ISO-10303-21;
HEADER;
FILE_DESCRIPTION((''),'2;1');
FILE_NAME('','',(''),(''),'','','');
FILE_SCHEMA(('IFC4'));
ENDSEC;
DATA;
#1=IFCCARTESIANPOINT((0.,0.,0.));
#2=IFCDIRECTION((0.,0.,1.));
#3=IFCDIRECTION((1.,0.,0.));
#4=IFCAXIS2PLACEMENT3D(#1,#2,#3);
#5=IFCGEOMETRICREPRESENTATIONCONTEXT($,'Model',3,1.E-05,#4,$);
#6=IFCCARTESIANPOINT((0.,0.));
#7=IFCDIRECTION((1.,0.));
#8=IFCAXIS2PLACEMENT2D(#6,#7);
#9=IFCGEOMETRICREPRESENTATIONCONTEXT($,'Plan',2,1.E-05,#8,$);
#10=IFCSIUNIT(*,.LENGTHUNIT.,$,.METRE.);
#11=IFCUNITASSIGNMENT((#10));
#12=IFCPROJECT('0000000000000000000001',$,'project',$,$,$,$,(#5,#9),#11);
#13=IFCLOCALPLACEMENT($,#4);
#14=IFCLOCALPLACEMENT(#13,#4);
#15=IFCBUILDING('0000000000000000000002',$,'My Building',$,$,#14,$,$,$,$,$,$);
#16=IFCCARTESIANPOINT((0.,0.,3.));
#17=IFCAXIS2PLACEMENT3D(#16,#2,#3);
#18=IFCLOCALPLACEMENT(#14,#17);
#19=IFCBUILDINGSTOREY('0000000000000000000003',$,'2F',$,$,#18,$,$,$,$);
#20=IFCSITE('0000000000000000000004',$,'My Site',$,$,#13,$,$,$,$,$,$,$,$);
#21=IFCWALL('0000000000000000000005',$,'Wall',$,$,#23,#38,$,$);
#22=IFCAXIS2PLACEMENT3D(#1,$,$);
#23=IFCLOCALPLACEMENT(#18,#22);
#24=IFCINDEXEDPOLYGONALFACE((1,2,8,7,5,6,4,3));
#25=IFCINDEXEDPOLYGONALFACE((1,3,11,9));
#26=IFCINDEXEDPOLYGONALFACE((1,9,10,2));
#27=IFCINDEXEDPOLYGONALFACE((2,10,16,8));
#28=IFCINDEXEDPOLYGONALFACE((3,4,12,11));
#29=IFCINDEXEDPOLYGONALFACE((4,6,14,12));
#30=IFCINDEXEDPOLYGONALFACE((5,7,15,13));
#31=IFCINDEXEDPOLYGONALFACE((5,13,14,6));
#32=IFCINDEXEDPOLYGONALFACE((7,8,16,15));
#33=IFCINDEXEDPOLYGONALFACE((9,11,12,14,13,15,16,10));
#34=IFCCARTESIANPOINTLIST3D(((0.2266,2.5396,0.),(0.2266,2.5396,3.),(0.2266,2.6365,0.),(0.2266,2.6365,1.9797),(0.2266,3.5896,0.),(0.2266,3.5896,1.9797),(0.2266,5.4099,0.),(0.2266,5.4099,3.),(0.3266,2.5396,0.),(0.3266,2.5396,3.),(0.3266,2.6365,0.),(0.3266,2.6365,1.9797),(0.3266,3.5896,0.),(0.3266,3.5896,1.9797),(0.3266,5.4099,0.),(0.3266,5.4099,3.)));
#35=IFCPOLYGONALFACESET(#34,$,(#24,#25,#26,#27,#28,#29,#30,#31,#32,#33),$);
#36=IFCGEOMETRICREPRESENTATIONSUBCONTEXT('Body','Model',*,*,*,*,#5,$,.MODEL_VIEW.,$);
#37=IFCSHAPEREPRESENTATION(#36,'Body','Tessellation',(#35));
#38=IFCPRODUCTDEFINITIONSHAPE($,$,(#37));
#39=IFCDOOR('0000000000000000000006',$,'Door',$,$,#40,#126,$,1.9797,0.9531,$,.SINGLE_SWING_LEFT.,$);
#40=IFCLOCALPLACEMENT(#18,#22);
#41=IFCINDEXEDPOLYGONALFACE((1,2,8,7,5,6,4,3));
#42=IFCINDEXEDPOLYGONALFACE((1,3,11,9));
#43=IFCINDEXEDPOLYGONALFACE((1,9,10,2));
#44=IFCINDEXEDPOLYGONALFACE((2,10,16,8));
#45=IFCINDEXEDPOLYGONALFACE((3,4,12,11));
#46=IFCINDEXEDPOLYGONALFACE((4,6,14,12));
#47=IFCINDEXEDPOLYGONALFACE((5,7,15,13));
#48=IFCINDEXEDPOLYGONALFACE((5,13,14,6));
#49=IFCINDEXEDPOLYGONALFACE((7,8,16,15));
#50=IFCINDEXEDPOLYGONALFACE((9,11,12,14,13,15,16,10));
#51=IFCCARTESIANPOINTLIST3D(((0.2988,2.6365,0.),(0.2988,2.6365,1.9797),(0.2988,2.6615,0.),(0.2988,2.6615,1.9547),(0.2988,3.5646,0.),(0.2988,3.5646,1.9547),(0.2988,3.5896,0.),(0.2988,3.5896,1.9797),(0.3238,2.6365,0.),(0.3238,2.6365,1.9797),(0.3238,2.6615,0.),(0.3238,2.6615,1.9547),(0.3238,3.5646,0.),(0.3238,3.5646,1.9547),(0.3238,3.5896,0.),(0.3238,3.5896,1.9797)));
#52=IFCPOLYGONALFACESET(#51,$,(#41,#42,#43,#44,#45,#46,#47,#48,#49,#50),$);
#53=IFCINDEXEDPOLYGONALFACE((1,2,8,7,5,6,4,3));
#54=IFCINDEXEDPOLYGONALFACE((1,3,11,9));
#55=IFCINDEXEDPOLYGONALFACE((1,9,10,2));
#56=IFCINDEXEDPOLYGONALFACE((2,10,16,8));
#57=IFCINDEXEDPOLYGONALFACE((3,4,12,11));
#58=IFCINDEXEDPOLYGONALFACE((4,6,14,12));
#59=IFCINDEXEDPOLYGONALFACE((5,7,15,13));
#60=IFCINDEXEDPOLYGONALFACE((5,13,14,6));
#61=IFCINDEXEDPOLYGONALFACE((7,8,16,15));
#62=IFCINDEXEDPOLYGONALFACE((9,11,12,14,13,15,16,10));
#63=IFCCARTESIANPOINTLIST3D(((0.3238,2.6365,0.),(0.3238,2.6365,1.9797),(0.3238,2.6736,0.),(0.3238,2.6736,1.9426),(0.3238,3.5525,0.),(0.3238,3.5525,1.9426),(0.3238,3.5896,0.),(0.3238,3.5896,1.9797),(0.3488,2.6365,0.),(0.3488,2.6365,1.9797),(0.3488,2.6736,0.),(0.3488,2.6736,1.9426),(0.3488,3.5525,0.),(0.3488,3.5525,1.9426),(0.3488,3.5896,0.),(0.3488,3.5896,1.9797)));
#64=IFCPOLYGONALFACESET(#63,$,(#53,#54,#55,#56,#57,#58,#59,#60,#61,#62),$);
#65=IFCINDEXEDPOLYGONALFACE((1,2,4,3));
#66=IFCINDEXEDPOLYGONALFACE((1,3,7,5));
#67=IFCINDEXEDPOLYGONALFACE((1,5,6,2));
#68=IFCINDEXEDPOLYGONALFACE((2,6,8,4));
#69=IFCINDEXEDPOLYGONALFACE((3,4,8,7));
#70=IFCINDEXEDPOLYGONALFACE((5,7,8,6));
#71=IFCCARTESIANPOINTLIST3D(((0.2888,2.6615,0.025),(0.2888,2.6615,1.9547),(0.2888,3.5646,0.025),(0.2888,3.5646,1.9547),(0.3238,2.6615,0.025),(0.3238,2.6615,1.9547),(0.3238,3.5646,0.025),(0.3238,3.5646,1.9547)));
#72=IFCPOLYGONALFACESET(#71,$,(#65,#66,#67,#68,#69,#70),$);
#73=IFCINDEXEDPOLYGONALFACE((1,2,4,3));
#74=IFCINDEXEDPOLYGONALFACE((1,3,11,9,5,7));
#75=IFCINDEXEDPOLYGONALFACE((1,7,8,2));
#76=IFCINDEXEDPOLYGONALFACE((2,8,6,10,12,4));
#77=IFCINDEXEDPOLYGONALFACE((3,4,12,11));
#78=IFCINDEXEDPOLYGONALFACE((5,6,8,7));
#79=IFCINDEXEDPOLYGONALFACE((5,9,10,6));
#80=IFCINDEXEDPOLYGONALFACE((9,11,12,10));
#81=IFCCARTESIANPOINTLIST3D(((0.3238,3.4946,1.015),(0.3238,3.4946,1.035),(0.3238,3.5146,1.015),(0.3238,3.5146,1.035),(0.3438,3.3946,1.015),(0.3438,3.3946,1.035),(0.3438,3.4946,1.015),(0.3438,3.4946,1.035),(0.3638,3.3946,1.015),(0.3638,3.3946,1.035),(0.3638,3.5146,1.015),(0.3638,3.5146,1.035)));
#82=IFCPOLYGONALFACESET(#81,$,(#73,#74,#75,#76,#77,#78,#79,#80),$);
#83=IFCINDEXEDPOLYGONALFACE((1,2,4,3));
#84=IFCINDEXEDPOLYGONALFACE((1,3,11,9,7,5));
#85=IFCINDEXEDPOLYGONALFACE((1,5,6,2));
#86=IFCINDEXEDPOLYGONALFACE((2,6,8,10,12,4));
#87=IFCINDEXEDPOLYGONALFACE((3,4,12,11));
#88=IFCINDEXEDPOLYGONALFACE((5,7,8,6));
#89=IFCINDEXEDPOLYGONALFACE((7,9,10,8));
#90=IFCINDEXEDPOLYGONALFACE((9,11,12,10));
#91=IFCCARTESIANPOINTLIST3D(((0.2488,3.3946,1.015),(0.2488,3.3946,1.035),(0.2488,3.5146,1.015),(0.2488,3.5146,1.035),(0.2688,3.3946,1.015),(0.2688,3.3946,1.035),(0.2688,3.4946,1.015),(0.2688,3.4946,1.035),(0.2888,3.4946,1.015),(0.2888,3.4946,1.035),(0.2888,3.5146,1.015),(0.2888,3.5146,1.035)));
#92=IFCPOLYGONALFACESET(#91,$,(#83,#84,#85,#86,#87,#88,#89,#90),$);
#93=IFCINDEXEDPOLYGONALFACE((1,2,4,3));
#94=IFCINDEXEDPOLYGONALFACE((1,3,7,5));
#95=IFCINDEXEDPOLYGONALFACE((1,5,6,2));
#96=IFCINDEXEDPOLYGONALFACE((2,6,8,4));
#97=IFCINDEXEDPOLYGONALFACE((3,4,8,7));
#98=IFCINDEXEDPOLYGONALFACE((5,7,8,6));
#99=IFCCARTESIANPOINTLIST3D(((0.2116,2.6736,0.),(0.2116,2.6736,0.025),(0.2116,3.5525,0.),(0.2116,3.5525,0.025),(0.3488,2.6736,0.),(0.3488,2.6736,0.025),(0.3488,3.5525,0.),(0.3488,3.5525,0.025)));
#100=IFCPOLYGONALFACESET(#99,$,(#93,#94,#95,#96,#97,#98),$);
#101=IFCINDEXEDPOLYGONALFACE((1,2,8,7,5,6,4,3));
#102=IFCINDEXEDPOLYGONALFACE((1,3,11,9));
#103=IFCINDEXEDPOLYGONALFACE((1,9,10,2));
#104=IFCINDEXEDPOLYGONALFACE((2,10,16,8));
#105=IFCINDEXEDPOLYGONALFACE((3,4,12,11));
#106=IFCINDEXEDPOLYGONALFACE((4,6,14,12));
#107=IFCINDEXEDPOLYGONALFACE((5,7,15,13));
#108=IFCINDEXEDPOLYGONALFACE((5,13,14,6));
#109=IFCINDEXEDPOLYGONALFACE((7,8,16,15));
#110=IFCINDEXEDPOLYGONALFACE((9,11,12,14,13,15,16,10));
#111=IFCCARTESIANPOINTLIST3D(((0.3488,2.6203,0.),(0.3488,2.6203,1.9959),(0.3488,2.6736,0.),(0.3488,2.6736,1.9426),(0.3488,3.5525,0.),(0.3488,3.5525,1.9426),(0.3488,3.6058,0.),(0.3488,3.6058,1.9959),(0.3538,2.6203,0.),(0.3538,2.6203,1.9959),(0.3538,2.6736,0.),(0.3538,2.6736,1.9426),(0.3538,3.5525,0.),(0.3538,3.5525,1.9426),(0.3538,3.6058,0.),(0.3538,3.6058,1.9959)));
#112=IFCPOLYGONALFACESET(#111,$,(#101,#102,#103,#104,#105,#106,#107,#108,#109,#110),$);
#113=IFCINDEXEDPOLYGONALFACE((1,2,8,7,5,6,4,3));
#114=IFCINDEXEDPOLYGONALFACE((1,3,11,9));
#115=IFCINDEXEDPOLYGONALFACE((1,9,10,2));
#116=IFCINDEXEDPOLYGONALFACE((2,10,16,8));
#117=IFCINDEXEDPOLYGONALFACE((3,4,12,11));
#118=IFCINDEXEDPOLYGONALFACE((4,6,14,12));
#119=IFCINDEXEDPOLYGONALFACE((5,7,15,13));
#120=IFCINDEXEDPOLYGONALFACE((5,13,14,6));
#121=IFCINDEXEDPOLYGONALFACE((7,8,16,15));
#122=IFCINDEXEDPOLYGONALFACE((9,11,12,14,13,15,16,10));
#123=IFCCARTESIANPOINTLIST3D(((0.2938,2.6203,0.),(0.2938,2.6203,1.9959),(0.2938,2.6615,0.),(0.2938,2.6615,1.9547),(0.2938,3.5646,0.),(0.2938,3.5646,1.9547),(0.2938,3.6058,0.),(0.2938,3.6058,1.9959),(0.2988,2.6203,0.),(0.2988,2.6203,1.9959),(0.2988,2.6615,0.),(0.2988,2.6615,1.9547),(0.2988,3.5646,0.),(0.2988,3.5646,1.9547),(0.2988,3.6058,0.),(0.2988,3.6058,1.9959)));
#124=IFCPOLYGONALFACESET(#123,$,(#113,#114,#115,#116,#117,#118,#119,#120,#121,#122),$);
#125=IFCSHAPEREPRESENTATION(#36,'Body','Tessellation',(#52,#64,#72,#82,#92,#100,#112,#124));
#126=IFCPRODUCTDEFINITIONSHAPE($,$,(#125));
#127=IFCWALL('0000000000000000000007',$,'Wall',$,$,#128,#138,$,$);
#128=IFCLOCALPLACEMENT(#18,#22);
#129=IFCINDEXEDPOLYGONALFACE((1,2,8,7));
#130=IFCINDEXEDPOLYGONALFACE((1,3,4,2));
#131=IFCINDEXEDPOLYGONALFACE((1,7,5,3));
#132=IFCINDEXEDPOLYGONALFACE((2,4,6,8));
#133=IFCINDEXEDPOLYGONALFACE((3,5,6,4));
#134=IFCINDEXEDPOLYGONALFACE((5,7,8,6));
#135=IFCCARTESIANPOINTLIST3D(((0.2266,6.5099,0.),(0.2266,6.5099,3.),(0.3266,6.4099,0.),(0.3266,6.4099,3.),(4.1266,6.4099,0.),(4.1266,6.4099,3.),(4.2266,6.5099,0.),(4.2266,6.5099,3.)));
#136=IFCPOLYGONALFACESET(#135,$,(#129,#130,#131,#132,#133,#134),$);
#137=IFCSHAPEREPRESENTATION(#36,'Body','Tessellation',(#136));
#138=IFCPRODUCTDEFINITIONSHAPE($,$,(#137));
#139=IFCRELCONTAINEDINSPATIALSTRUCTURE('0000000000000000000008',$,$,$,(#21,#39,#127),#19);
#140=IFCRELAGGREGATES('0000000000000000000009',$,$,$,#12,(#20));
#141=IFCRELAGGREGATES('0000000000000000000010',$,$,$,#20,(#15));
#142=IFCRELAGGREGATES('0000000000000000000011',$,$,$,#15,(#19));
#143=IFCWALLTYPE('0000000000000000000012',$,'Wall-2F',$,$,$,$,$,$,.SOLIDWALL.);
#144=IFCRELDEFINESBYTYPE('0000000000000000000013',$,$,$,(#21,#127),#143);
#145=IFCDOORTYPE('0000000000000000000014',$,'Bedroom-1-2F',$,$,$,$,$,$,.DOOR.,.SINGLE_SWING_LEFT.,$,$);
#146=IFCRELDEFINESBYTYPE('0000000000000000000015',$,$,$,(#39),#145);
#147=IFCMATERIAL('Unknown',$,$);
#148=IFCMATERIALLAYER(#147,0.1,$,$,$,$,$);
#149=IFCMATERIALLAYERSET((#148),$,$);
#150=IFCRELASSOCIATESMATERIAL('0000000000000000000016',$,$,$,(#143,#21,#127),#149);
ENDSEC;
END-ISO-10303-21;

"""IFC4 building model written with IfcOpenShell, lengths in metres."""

from ifc_helpers import new_model, entity, si_unit, frame, origin_with_axes, origin_2d_with_axis, place, context, subcontext, project, spatial, line, indexed_curve, outline, extrude, shape, source, transform, mapped, material, layer, layer_set, layer_usage, type_object, type_shapes, element, fill, save


model = new_model("IFC4")

# Units and contexts
model_context = context("Model", 3, precision=1e-05, world=origin_with_axes())
plan_context = context("Plan", 2, precision=1e-05, world=origin_2d_with_axis())
body_context_1 = subcontext(model_context, "Body", "Model", "MODEL_VIEW")
body_context_2 = subcontext(plan_context, "Body", "Plan", "PLAN_VIEW")
ifc_project = project(units=[si_unit("LENGTHUNIT", "METRE")], contexts=[model_context, plan_context])

# Site, building, storey
site_placement = place(None, origin_with_axes())
site = spatial("IfcSite", under=ifc_project, at=site_placement, Name="My Site")
building_placement = place(site_placement, origin_with_axes())
building = spatial("IfcBuilding", under=site, at=building_placement, Name="My Building")
storey_placement = place(building_placement, frame((0.0, 0.0, 3.0), z_axis=(0.0, 0.0, 1.0), x_axis=(1.0, 0.0, 0.0)))
storey = spatial("IfcBuildingStorey", under=building, at=storey_placement, Name="2F")

# Shared definitions
ifc_material = material(Name="Unknown")

# Shared definitions
ifc_layer_1 = layer(ifc_material, 0.1)
ifc_layer_set_1 = layer_set([ifc_layer_1])
wall_type = type_object("IfcWallType", Name="Wall-2F", PredefinedType="SOLIDWALL", material=ifc_layer_set_1)

# Wall, opening, door
ifc_layer_usage_1 = layer_usage(ifc_layer_set_1, "AXIS2", "POSITIVE", 0.0)
wall_1_placement = place(storey_placement, frame((0.3266, 2.5396, 0.0), z_axis=(0.0, 0.0, 1.0), x_axis=(0.0, 1.0, 0.0)))
wall_1 = element("IfcWall", 1, at=wall_1_placement, inside=storey, type_object=wall_type, material=ifc_layer_usage_1, Name="Wall", context=body_context_1, shape_type="SweptSolid", body=[
    extrude(outline(indexed_curve([(0.0, 0.0), (0.0, 0.1), (2.8703, 0.1), (2.8703, 0.0)], segments=[line(1, 2, 3, 4, 1)])), origin_with_axes(), (0.0, 0.0, 1.0), 3.0),
])
shared_shape_1 = source(origin_with_axes(), body_context_1, "Body", "SweptSolid", [
    extrude(outline(indexed_curve([(0.0, 0.0), (0.9531, 0.0), (0.9531, 1.9797), (0.0, 1.9797)], segments=[line(1, 2, 3, 4, 1)])), frame((0.0, -0.6, 0.0), z_axis=(0.0, -1.0, 0.0), x_axis=(1.0, 0.0, 0.0)), (0.0, 0.0, -1.0), 1.2),
])
opening_1_placement = place(wall_1_placement, frame((0.0969, -0.0222, 0.0), z_axis=(0.0, 0.0, 1.0), x_axis=(1.0, 0.0, 0.0)))
opening_1 = element("IfcOpeningElement", 2, at=opening_1_placement, cuts=wall_1, PredefinedType="OPENING", context=body_context_1, shape_type="MappedRepresentation", body=[
    mapped(shared_shape_1, transform((0.0, 0.0, 0.0), x_axis=(1.0, 0.0, 0.0), y_axis=(0.0, 1.0, 0.0), z_axis=(0.0, 0.0, 1.0), scale=1.0)),
])
door_type_1 = type_object("IfcDoorType", Name="Bedroom-1-2F", OperationType="SINGLE_SWING_LEFT", PredefinedType="DOOR")
shared_shape_2 = source(origin_with_axes(), body_context_1, "Body", "SweptSolid", [
    extrude(outline(indexed_curve([(0.0, 0.0), (0.0, 1.9797), (0.9531, 1.9797), (0.9531, 0.0), (0.9281, 0.0), (0.9281, 1.9547), (0.025, 1.9547), (0.025, 0.0)], segments=[line(1, 2, 3, 4, 5, 6, 7, 8, 1)])), frame((0.0, 0.025, 0.0), z_axis=(0.0, -1.0, 0.0), x_axis=(1.0, 0.0, 0.0)), (0.0, 0.0, -1.0), 0.025),
    extrude(outline(indexed_curve([(0.0, 0.0), (0.0, 1.9797), (0.9531, 1.9797), (0.9531, 0.0), (0.9161, 0.0), (0.9161, 1.9426), (0.0371, 1.9426), (0.0371, 0.0)], segments=[line(1, 2, 3, 4, 5, 6, 7, 8, 1)])), frame((0.0, 0.0, 0.0), z_axis=(0.0, -1.0, 0.0), x_axis=(1.0, 0.0, 0.0)), (0.0, 0.0, -1.0), 0.025),
    extrude(outline(indexed_curve([(0.0, 0.0), (0.9031, 0.0), (0.9031, 0.035), (0.0, 0.035)], segments=[line(1, 2, 3, 4, 1)])), frame((0.025, 0.025, 0.025), z_axis=(0.0, 0.0, 1.0), x_axis=(1.0, 0.0, 0.0)), (0.0, 0.0, 1.0), 1.9297),
    extrude(outline(indexed_curve([(0.0, 0.0), (0.0, -0.04), (-0.12, -0.04), (-0.12, -0.02), (-0.02, -0.02), (-0.02, 0.0)], segments=[line(1, 2, 3, 4, 5, 6, 1)])), frame((0.8781, 0.025, 1.015), z_axis=(0.0, 0.0, 1.0), x_axis=(1.0, 0.0, 0.0)), (0.0, 0.0, 1.0), 0.02),
    extrude(outline(indexed_curve([(0.0, 0.0), (0.0, 0.04), (-0.12, 0.04), (-0.12, 0.02), (-0.02, 0.02), (-0.02, 0.0)], segments=[line(1, 2, 3, 4, 5, 6, 1)])), frame((0.8781, 0.06, 1.015), z_axis=(0.0, 0.0, 1.0), x_axis=(1.0, 0.0, 0.0)), (0.0, 0.0, 1.0), 0.02),
    extrude(outline(indexed_curve([(0.0, 0.0), (0.879, 0.0), (0.879, 0.1372), (0.0, 0.1372)], segments=[line(1, 2, 3, 4, 1)])), frame((0.0371, 0.0, 0.0), z_axis=(0.0, 0.0, 1.0), x_axis=(1.0, 0.0, 0.0)), (0.0, 0.0, 1.0), 0.025),
    extrude(outline(indexed_curve([(0.0, 0.0), (0.0, 1.9959), (0.9855, 1.9959), (0.9855, 0.0), (0.9322, 0.0), (0.9322, 1.9426), (0.0532, 1.9426), (0.0532, 0.0)], segments=[line(1, 2, 3, 4, 5, 6, 7, 8, 1)])), frame((-0.0162, -0.005, 0.0), z_axis=(0.0, -1.0, 0.0), x_axis=(1.0, 0.0, 0.0)), (0.0, 0.0, -1.0), 0.005),
    extrude(outline(indexed_curve([(0.0, 0.0), (0.0, 1.9959), (0.9855, 1.9959), (0.9855, 0.0), (0.9443, 0.0), (0.9443, 1.9547), (0.0412, 1.9547), (0.0412, 0.0)], segments=[line(1, 2, 3, 4, 5, 6, 7, 8, 1)])), frame((-0.0162, 0.05, 0.0), z_axis=(0.0, -1.0, 0.0), x_axis=(1.0, 0.0, 0.0)), (0.0, 0.0, -1.0), 0.005),
])
shared_shape_3 = source(origin_with_axes(), body_context_2, "Body", "Curve2D", [
    entity("IfcIndexedPolyCurve", entity("IfcCartesianPointList2D", [[0.0, 0.0], [0.0, 0.05], [0.025, 0.05], [0.025, 0.025], [0.0371, 0.025], [0.0371, 0.0]]), [entity("IfcLineIndex", [1, 2, 3, 4, 5, 6, 1])]),
    entity("IfcIndexedPolyCurve", entity("IfcCartesianPointList2D", [[0.9531, 0.0], [0.9531, 0.05], [0.9281, 0.05], [0.9281, 0.025], [0.9161, 0.025], [0.9161, 0.0]]), [entity("IfcLineIndex", [1, 2, 3, 4, 5, 6, 1])]),
    entity("IfcTrimmedCurve", entity("IfcEllipse", entity("IfcAxis2Placement2D", entity("IfcCartesianPoint", [0.06, 0.05]), entity("IfcDirection", [1.0, 0.0])), 0.8681, 0.9031), [entity("IfcCartesianPoint", [0.9281, 0.05])], [entity("IfcCartesianPoint", [0.06, 0.9531])], True, "CARTESIAN"),
    entity("IfcIndexedPolyCurve", entity("IfcCartesianPointList2D", [[0.025, 0.05], [0.06, 0.05], [0.06, 0.9531], [0.025, 0.9531]]), [entity("IfcLineIndex", [1, 2, 3, 4, 1])]),
])
type_shapes(door_type_1, [shared_shape_2, shared_shape_3])
door_1_placement = place(opening_1_placement, frame((0.0, 0.0, 0.0), z_axis=(0.0, 0.0, 1.0), x_axis=(1.0, 0.0, 0.0)))
door_1 = element("IfcDoor", 3, at=door_1_placement, inside=storey, type_object=door_type_1, Name="Door", OperationType="SINGLE_SWING_LEFT", OverallHeight=1.9797, OverallWidth=0.9531, shapes=[
    shape(body_context_1, "Body", "MappedRepresentation", [mapped(shared_shape_2, transform((0.0, 0.0, 0.0), x_axis=(1.0, 0.0, 0.0), y_axis=(0.0, 1.0, 0.0), z_axis=(0.0, 0.0, 1.0), scale=1.0))]),
    shape(body_context_2, "Body", "MappedRepresentation", [mapped(shared_shape_3, transform((0.0, 0.0, 0.0), x_axis=(1.0, 0.0, 0.0), y_axis=(0.0, 1.0, 0.0), z_axis=(0.0, 0.0, 1.0), scale=1.0))]),
])
fill(opening_1, door_1)

# Wall
ifc_layer_usage_2 = layer_usage(ifc_layer_set_1, "AXIS2", "POSITIVE", 0.0)
wall_2_placement = place(storey_placement, frame((0.2266, 6.4099, 0.0), z_axis=(0.0, 0.0, 1.0), x_axis=(1.0, 0.0, 0.0)))
element("IfcWall", 4, at=wall_2_placement, inside=storey, type_object=wall_type, material=ifc_layer_usage_2, Name="Wall", context=body_context_1, shape_type="SweptSolid", body=[
    extrude(outline(indexed_curve([(0.1, 0.0), (0.0, 0.1), (4.0, 0.1), (3.9, 0.0)], segments=[line(1, 2, 3, 4, 1)])), origin_with_axes(), (0.0, 0.0, 1.0), 3.0),
])

save(model, "model.ifc")
